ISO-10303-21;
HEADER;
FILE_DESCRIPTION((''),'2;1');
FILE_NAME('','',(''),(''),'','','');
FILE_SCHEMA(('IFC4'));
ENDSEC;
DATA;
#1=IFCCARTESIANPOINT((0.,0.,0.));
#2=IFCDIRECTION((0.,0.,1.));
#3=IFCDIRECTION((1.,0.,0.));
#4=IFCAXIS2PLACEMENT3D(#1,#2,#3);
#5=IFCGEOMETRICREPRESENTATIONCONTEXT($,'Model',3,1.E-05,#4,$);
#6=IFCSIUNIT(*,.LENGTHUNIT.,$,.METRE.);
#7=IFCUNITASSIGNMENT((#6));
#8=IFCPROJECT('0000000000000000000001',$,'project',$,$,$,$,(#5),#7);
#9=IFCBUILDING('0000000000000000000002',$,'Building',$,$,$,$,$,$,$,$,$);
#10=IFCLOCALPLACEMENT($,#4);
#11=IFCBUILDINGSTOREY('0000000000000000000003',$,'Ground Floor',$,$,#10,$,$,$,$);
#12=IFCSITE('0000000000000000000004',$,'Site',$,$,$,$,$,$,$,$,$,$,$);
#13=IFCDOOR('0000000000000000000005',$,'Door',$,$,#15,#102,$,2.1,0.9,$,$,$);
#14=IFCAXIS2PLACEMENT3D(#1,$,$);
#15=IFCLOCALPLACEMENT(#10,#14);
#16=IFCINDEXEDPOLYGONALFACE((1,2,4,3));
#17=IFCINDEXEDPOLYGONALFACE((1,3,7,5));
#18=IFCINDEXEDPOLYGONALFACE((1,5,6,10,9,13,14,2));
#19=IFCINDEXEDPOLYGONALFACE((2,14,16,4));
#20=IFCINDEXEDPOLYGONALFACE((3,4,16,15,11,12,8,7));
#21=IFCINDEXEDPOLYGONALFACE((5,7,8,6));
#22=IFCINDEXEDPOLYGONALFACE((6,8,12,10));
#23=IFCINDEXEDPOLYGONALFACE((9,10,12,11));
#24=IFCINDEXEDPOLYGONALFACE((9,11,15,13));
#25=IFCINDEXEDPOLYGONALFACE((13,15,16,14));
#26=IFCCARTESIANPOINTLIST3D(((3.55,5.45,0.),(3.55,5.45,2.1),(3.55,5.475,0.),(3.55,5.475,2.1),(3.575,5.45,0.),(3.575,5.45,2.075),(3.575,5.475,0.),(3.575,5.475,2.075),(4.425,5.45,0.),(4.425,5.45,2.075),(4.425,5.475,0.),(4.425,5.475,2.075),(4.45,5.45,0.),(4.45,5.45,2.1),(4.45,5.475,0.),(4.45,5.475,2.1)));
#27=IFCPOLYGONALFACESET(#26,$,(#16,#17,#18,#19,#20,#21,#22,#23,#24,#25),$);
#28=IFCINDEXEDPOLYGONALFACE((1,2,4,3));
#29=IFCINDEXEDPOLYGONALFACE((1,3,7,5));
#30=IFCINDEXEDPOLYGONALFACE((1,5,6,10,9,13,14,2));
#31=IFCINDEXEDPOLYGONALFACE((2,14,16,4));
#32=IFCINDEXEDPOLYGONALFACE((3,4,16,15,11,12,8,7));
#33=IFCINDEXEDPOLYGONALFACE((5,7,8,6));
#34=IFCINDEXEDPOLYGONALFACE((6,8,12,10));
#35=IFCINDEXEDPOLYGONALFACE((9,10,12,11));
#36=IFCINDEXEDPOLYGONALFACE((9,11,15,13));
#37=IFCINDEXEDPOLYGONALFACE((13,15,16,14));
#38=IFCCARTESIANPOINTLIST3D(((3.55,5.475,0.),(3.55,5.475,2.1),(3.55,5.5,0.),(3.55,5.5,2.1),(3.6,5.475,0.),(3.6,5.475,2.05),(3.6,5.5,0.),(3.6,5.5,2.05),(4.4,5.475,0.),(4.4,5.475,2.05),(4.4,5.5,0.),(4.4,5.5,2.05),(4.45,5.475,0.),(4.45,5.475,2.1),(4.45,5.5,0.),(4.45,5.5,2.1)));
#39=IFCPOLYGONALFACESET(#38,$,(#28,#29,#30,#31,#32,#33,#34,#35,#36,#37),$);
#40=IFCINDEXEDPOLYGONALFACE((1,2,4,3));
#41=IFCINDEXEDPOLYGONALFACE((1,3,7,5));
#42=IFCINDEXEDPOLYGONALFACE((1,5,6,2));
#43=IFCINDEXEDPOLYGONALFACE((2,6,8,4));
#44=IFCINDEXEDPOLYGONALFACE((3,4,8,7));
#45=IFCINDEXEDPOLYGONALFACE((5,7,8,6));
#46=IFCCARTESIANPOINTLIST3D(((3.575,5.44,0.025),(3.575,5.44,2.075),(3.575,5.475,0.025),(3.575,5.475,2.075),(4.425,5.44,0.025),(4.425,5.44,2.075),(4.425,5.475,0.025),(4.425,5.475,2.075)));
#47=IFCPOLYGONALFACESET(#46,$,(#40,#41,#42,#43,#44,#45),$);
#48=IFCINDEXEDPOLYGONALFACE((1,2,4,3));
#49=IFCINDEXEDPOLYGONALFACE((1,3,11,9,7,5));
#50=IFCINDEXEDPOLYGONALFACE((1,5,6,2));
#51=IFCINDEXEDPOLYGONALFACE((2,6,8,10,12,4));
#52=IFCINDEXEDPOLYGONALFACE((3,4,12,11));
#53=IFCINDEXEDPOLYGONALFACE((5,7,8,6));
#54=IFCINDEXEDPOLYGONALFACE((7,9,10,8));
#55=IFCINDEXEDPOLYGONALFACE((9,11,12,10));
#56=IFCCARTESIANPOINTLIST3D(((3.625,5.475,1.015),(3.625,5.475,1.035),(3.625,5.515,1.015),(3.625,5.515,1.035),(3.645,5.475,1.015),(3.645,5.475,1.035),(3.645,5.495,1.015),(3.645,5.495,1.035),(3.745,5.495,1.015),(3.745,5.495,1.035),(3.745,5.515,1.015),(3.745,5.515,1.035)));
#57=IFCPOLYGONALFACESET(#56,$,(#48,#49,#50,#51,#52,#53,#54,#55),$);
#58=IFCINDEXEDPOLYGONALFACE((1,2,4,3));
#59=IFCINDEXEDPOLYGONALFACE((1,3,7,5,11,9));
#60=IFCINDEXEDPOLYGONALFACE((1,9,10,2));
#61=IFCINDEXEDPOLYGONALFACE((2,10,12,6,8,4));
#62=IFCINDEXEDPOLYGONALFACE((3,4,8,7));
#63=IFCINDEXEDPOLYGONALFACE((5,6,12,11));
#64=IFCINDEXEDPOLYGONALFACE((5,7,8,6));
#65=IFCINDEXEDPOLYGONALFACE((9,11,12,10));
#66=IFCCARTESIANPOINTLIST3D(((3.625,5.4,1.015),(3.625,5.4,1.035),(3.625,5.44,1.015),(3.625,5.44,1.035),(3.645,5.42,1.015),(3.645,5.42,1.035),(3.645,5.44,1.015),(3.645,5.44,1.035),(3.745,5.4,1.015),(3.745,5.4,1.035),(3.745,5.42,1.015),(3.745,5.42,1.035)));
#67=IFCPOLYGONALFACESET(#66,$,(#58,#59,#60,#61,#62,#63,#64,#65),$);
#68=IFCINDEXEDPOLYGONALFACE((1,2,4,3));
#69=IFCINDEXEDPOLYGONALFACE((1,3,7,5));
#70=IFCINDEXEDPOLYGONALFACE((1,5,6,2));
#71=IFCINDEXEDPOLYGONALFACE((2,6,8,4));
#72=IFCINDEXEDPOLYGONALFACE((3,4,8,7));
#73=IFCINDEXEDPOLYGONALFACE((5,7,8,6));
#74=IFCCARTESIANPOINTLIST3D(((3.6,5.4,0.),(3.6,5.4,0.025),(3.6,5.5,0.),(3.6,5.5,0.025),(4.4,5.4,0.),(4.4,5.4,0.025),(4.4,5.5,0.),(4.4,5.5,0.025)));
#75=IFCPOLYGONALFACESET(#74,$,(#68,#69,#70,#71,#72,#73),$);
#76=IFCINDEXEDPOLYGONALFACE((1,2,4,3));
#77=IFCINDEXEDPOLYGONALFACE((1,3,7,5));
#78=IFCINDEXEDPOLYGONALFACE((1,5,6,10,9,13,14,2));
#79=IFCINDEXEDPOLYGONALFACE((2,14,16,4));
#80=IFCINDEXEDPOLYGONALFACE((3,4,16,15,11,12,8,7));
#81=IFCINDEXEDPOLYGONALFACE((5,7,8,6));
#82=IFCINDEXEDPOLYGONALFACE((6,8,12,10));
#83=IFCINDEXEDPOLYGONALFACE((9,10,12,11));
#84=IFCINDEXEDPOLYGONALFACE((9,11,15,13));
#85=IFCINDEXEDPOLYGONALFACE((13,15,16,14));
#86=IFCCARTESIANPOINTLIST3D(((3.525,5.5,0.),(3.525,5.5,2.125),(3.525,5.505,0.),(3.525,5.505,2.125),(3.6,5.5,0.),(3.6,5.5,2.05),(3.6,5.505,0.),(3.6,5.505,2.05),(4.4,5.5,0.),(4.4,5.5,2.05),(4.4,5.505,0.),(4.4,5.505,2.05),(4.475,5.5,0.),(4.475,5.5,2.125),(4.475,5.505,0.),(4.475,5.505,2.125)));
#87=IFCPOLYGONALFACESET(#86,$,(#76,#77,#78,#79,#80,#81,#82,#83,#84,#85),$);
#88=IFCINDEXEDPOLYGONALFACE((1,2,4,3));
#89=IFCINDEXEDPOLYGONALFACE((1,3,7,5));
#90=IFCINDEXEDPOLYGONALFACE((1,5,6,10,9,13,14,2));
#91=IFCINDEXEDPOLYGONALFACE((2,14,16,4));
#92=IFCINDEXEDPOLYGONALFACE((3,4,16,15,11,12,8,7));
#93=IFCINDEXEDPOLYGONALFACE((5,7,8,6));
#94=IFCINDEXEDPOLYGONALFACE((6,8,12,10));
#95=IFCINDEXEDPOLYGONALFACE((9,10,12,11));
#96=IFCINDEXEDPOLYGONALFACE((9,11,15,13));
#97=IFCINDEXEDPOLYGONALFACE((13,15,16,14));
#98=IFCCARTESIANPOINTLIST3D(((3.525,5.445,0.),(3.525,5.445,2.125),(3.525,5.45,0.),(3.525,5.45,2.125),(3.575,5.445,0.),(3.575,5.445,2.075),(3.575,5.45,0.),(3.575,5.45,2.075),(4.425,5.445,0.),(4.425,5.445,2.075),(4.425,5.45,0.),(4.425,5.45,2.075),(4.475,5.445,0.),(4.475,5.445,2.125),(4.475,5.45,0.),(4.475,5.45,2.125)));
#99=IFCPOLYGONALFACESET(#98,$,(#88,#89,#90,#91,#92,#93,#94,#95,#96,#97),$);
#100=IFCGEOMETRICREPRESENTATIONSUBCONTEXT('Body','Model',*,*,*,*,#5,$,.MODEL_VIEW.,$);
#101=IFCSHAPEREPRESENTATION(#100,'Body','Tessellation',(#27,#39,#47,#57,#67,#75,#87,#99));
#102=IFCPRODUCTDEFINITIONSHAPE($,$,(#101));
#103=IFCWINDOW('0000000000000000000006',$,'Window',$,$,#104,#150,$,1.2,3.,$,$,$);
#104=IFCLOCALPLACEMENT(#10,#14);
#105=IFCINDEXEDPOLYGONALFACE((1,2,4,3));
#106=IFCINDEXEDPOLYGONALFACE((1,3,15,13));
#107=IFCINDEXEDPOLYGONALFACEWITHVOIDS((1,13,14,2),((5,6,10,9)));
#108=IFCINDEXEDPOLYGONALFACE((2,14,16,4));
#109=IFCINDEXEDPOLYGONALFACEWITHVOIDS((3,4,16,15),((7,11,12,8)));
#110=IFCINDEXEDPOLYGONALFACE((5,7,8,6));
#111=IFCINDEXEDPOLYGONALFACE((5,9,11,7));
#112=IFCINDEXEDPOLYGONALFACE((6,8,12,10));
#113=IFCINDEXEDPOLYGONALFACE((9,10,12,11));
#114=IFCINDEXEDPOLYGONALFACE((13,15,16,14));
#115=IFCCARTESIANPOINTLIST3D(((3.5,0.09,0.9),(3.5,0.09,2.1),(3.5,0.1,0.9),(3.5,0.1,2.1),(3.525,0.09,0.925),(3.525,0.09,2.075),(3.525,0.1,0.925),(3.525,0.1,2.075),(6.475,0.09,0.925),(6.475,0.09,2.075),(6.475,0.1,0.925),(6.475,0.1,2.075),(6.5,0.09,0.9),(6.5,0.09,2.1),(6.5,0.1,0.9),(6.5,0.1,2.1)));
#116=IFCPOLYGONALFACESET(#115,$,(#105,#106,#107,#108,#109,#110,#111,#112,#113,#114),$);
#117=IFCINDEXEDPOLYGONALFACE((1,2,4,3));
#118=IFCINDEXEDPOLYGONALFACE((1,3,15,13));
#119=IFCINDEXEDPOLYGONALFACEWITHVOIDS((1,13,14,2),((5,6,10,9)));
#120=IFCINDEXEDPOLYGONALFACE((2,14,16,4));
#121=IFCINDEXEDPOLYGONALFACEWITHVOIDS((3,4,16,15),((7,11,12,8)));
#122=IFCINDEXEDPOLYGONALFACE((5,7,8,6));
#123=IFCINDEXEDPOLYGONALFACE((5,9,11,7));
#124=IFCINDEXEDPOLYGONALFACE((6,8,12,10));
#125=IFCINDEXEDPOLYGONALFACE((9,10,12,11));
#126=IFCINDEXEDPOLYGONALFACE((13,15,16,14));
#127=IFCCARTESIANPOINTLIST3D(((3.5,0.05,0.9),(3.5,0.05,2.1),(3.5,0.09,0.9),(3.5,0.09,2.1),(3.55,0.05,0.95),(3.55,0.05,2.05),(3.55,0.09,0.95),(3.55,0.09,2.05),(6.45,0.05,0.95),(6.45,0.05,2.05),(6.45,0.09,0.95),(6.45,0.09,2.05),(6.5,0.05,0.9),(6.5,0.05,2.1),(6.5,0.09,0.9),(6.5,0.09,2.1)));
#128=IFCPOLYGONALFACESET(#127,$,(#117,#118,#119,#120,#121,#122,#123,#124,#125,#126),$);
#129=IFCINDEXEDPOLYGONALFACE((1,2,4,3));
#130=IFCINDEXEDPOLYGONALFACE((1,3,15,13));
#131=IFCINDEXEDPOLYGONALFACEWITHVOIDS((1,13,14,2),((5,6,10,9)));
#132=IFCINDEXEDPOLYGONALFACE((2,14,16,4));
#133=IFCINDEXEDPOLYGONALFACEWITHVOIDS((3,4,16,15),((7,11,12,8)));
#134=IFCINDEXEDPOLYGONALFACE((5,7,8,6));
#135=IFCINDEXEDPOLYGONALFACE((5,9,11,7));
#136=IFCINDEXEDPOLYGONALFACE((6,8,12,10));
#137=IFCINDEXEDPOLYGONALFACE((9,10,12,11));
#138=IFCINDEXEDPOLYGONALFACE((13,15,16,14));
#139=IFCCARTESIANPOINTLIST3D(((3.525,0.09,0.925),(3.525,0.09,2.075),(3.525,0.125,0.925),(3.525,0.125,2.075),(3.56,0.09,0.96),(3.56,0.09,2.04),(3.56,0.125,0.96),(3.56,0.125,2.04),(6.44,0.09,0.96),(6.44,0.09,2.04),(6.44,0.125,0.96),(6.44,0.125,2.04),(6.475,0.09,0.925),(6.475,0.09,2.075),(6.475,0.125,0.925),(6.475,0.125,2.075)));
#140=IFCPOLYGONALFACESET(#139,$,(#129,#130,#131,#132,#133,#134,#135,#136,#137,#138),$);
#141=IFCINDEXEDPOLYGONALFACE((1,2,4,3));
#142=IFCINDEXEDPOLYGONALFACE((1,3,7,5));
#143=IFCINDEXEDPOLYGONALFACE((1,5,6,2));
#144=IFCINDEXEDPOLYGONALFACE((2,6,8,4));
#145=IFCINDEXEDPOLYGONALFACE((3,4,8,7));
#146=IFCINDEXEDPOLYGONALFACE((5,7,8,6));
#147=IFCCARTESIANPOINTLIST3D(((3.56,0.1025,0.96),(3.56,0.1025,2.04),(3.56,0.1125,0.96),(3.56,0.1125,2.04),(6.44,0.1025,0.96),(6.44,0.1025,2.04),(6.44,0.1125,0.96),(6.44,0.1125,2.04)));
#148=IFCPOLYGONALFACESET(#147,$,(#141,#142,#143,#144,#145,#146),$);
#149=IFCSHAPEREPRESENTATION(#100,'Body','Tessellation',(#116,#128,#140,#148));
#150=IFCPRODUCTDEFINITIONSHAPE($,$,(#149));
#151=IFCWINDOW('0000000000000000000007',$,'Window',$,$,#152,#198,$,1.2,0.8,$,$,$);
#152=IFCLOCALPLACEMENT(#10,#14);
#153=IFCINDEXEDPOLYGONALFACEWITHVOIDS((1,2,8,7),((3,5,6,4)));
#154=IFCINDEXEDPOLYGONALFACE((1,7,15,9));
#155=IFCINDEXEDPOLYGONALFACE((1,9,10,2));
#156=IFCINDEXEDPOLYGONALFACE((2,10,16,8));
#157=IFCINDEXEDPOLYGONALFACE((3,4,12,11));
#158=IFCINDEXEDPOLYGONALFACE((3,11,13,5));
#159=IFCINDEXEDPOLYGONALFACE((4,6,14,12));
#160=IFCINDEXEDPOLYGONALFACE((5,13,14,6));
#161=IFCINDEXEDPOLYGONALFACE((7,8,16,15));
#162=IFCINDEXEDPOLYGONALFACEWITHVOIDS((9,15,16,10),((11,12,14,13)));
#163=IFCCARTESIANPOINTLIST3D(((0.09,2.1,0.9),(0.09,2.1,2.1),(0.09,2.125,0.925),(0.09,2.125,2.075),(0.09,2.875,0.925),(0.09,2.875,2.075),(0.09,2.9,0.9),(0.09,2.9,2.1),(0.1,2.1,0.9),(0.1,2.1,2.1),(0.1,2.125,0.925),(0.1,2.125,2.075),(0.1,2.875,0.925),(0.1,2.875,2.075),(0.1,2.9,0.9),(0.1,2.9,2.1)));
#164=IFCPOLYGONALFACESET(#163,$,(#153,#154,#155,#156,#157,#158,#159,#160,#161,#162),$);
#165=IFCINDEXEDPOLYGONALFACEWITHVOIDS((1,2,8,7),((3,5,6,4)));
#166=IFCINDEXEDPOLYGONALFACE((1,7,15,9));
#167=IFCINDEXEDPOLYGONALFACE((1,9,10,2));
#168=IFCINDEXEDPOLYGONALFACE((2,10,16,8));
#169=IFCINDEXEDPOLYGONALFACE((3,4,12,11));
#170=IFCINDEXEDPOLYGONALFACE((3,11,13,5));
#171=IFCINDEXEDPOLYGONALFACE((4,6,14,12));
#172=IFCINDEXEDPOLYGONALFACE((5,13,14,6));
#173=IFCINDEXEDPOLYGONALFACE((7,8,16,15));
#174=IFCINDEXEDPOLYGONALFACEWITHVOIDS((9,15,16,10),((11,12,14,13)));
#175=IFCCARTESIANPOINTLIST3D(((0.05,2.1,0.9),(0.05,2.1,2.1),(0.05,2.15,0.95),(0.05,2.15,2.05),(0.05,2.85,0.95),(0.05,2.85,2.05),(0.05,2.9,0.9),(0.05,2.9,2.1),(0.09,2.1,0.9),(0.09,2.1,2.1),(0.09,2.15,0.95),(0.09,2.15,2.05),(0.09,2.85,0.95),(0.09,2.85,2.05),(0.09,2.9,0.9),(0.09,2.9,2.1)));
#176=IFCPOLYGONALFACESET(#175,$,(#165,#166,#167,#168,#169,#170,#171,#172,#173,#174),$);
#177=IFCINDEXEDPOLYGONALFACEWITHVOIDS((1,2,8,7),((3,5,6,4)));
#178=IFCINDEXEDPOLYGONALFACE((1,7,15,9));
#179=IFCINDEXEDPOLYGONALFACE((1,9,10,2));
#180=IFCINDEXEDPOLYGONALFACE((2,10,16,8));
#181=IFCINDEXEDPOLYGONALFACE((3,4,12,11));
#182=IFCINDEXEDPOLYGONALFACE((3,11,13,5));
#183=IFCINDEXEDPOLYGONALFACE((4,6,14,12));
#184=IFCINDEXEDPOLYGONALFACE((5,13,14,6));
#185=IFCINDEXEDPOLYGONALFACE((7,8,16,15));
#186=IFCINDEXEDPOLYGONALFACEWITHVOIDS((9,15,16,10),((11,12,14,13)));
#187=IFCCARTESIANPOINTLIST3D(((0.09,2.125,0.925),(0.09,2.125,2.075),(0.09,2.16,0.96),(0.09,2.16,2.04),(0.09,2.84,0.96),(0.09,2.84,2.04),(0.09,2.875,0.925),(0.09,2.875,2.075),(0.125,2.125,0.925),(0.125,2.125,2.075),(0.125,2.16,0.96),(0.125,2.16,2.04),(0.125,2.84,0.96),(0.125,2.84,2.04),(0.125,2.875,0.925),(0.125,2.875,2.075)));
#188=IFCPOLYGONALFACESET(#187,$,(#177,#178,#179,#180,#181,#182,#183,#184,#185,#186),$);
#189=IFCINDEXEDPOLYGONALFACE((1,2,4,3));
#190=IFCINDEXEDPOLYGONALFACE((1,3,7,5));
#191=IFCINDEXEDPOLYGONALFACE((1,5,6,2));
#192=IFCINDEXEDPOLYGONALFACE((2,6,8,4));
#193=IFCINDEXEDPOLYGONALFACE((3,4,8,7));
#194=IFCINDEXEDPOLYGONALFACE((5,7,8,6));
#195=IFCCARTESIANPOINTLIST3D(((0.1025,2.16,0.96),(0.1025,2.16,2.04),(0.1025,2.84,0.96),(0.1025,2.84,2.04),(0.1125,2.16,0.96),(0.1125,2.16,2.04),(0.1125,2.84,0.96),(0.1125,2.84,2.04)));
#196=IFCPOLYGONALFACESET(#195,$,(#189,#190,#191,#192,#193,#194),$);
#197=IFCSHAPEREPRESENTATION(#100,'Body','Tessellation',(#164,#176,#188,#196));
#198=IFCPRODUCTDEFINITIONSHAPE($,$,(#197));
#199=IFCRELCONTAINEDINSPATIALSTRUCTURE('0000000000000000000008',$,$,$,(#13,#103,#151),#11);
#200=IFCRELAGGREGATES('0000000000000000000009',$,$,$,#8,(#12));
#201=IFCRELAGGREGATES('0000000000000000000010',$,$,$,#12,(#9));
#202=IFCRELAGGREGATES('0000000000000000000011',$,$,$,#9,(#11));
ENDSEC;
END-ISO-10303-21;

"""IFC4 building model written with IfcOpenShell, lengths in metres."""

from ifc_helpers import new_model, si_unit, frame, origin_with_axes, place, context, subcontext, project, spatial, line, indexed_curve, outline, extrude, element, save


model = new_model("IFC4")

# Units and contexts
model_context = context("Model", 3, precision=1e-05, world=origin_with_axes())
body_context = subcontext(model_context, "Body", "Model", "MODEL_VIEW")
ifc_project = project(units=[si_unit("LENGTHUNIT", "METRE")], contexts=[model_context])

# Site, building, storey
site = spatial("IfcSite", under=ifc_project, Name="Site")
building = spatial("IfcBuilding", under=site, Name="Building")
storey_placement = place(None, origin_with_axes())
storey = spatial("IfcBuildingStorey", under=building, at=storey_placement, Name="Ground Floor")

# Door
door_1_placement = place(storey_placement, frame((4.45, 5.5, 0.0), z_axis=(0.0, 0.0, 1.0), x_axis=(-1.0, 0.0, 0.0)))
element("IfcDoor", 1, at=door_1_placement, inside=storey, Name="Door", OverallHeight=2.1, OverallWidth=0.9, context=body_context, shape_type="SweptSolid", body=[
    extrude(outline(indexed_curve([(0.0, 0.0), (0.0, 2.1), (0.9, 2.1), (0.9, 0.0), (0.875, 0.0), (0.875, 2.075), (0.025, 2.075), (0.025, 0.0)], segments=[line(1, 2, 3, 4, 5, 6, 7, 8, 1)])), frame((0.0, 0.025, 0.0), z_axis=(0.0, -1.0, 0.0), x_axis=(1.0, 0.0, 0.0)), (0.0, 0.0, -1.0), 0.025),
    extrude(outline(indexed_curve([(0.0, 0.0), (0.0, 2.1), (0.9, 2.1), (0.9, 0.0), (0.85, 0.0), (0.85, 2.05), (0.05, 2.05), (0.05, 0.0)], segments=[line(1, 2, 3, 4, 5, 6, 7, 8, 1)])), frame((0.0, 0.0, 0.0), z_axis=(0.0, -1.0, 0.0), x_axis=(1.0, 0.0, 0.0)), (0.0, 0.0, -1.0), 0.025),
    extrude(outline(indexed_curve([(0.0, 0.0), (0.85, 0.0), (0.85, 0.035), (0.0, 0.035)], segments=[line(1, 2, 3, 4, 1)])), frame((0.025, 0.025, 0.025), z_axis=(0.0, 0.0, 1.0), x_axis=(1.0, 0.0, 0.0)), (0.0, 0.0, 1.0), 2.05),
    extrude(outline(indexed_curve([(0.0, 0.0), (0.0, -0.04), (-0.12, -0.04), (-0.12, -0.02), (-0.02, -0.02), (-0.02, 0.0)], segments=[line(1, 2, 3, 4, 5, 6, 1)])), frame((0.825, 0.025, 1.015), z_axis=(0.0, 0.0, 1.0), x_axis=(1.0, 0.0, 0.0)), (0.0, 0.0, 1.0), 0.02),
    extrude(outline(indexed_curve([(0.0, 0.0), (0.0, 0.04), (-0.12, 0.04), (-0.12, 0.02), (-0.02, 0.02), (-0.02, 0.0)], segments=[line(1, 2, 3, 4, 5, 6, 1)])), frame((0.825, 0.06, 1.015), z_axis=(0.0, 0.0, 1.0), x_axis=(1.0, 0.0, 0.0)), (0.0, 0.0, 1.0), 0.02),
    extrude(outline(indexed_curve([(0.0, 0.0), (0.8, 0.0), (0.8, 0.1), (0.0, 0.1)], segments=[line(1, 2, 3, 4, 1)])), frame((0.05, 0.0, 0.0), z_axis=(0.0, 0.0, 1.0), x_axis=(1.0, 0.0, 0.0)), (0.0, 0.0, 1.0), 0.025),
    extrude(outline(indexed_curve([(0.0, 0.0), (0.0, 2.125), (0.95, 2.125), (0.95, 0.0), (0.875, 0.0), (0.875, 2.05), (0.075, 2.05), (0.075, 0.0)], segments=[line(1, 2, 3, 4, 5, 6, 7, 8, 1)])), frame((-0.025, -0.005, 0.0), z_axis=(0.0, -1.0, 0.0), x_axis=(1.0, 0.0, 0.0)), (0.0, 0.0, -1.0), 0.005),
    extrude(outline(indexed_curve([(0.0, 0.0), (0.0, 2.125), (0.95, 2.125), (0.95, 0.0), (0.9, 0.0), (0.9, 2.075), (0.05, 2.075), (0.05, 0.0)], segments=[line(1, 2, 3, 4, 5, 6, 7, 8, 1)])), frame((-0.025, 0.05, 0.0), z_axis=(0.0, -1.0, 0.0), x_axis=(1.0, 0.0, 0.0)), (0.0, 0.0, -1.0), 0.005),
])

# Windows
window_1_placement = place(storey_placement, frame((3.5, 0.0, 0.9), z_axis=(0.0, 0.0, 1.0), x_axis=(1.0, 0.0, 0.0)))
element("IfcWindow", 2, at=window_1_placement, inside=storey, Name="Window", OverallHeight=1.2, OverallWidth=3.0, context=body_context, shape_type="SweptSolid", body=[
    extrude(outline(indexed_curve([(0.0, 0.0), (3.0, 0.0), (3.0, 1.2), (0.0, 1.2)], segments=[line(1, 2, 3, 4, 1)]), holes=[indexed_curve([(0.025, 0.025), (2.975, 0.025), (2.975, 1.175), (0.025, 1.175)], segments=[line(1, 2, 3, 4, 1)])]), frame((0.0, 0.09, 0.0), z_axis=(0.0, -1.0, 0.0), x_axis=(1.0, 0.0, 0.0)), (0.0, 0.0, -1.0), 0.01),
    extrude(outline(indexed_curve([(0.0, 0.0), (3.0, 0.0), (3.0, 1.2), (0.0, 1.2)], segments=[line(1, 2, 3, 4, 1)]), holes=[indexed_curve([(0.05, 0.05), (2.95, 0.05), (2.95, 1.15), (0.05, 1.15)], segments=[line(1, 2, 3, 4, 1)])]), frame((0.0, 0.05, 0.0), z_axis=(0.0, -1.0, 0.0), x_axis=(1.0, 0.0, 0.0)), (0.0, 0.0, -1.0), 0.04),
    extrude(outline(indexed_curve([(0.0, 0.0), (2.95, 0.0), (2.95, 1.15), (0.0, 1.15)], segments=[line(1, 2, 3, 4, 1)]), holes=[indexed_curve([(0.035, 0.035), (2.915, 0.035), (2.915, 1.115), (0.035, 1.115)], segments=[line(1, 2, 3, 4, 1)])]), frame((0.025, 0.09, 0.025), z_axis=(0.0, -1.0, 0.0), x_axis=(1.0, 0.0, 0.0)), (0.0, 0.0, -1.0), 0.035),
    extrude(outline(indexed_curve([(0.035, 0.035), (2.915, 0.035), (2.915, 1.115), (0.035, 1.115)], segments=[line(1, 2, 3, 4, 1)])), frame((0.025, 0.1025, 0.025), z_axis=(0.0, -1.0, 0.0), x_axis=(1.0, 0.0, 0.0)), (0.0, 0.0, -1.0), 0.01),
])
window_2_placement = place(storey_placement, frame((0.0, 2.9, 0.9), z_axis=(0.0, 0.0, 1.0), x_axis=(0.0, -1.0, 0.0)))
element("IfcWindow", 3, at=window_2_placement, inside=storey, Name="Window", OverallHeight=1.2, OverallWidth=0.8, context=body_context, shape_type="SweptSolid", body=[
    extrude(outline(indexed_curve([(0.0, 0.0), (0.8, 0.0), (0.8, 1.2), (0.0, 1.2)], segments=[line(1, 2, 3, 4, 1)]), holes=[indexed_curve([(0.025, 0.025), (0.775, 0.025), (0.775, 1.175), (0.025, 1.175)], segments=[line(1, 2, 3, 4, 1)])]), frame((0.0, 0.09, 0.0), z_axis=(0.0, -1.0, 0.0), x_axis=(1.0, 0.0, 0.0)), (0.0, 0.0, -1.0), 0.01),
    extrude(outline(indexed_curve([(0.0, 0.0), (0.8, 0.0), (0.8, 1.2), (0.0, 1.2)], segments=[line(1, 2, 3, 4, 1)]), holes=[indexed_curve([(0.05, 0.05), (0.75, 0.05), (0.75, 1.15), (0.05, 1.15)], segments=[line(1, 2, 3, 4, 1)])]), frame((0.0, 0.05, 0.0), z_axis=(0.0, -1.0, 0.0), x_axis=(1.0, 0.0, 0.0)), (0.0, 0.0, -1.0), 0.04),
    extrude(outline(indexed_curve([(0.0, 0.0), (0.75, 0.0), (0.75, 1.15), (0.0, 1.15)], segments=[line(1, 2, 3, 4, 1)]), holes=[indexed_curve([(0.035, 0.035), (0.715, 0.035), (0.715, 1.115), (0.035, 1.115)], segments=[line(1, 2, 3, 4, 1)])]), frame((0.025, 0.09, 0.025), z_axis=(0.0, -1.0, 0.0), x_axis=(1.0, 0.0, 0.0)), (0.0, 0.0, -1.0), 0.035),
    extrude(outline(indexed_curve([(0.035, 0.035), (0.715, 0.035), (0.715, 1.115), (0.035, 1.115)], segments=[line(1, 2, 3, 4, 1)])), frame((0.025, 0.1025, 0.025), z_axis=(0.0, -1.0, 0.0), x_axis=(1.0, 0.0, 0.0)), (0.0, 0.0, -1.0), 0.01),
])

save(model, "model.ifc")
